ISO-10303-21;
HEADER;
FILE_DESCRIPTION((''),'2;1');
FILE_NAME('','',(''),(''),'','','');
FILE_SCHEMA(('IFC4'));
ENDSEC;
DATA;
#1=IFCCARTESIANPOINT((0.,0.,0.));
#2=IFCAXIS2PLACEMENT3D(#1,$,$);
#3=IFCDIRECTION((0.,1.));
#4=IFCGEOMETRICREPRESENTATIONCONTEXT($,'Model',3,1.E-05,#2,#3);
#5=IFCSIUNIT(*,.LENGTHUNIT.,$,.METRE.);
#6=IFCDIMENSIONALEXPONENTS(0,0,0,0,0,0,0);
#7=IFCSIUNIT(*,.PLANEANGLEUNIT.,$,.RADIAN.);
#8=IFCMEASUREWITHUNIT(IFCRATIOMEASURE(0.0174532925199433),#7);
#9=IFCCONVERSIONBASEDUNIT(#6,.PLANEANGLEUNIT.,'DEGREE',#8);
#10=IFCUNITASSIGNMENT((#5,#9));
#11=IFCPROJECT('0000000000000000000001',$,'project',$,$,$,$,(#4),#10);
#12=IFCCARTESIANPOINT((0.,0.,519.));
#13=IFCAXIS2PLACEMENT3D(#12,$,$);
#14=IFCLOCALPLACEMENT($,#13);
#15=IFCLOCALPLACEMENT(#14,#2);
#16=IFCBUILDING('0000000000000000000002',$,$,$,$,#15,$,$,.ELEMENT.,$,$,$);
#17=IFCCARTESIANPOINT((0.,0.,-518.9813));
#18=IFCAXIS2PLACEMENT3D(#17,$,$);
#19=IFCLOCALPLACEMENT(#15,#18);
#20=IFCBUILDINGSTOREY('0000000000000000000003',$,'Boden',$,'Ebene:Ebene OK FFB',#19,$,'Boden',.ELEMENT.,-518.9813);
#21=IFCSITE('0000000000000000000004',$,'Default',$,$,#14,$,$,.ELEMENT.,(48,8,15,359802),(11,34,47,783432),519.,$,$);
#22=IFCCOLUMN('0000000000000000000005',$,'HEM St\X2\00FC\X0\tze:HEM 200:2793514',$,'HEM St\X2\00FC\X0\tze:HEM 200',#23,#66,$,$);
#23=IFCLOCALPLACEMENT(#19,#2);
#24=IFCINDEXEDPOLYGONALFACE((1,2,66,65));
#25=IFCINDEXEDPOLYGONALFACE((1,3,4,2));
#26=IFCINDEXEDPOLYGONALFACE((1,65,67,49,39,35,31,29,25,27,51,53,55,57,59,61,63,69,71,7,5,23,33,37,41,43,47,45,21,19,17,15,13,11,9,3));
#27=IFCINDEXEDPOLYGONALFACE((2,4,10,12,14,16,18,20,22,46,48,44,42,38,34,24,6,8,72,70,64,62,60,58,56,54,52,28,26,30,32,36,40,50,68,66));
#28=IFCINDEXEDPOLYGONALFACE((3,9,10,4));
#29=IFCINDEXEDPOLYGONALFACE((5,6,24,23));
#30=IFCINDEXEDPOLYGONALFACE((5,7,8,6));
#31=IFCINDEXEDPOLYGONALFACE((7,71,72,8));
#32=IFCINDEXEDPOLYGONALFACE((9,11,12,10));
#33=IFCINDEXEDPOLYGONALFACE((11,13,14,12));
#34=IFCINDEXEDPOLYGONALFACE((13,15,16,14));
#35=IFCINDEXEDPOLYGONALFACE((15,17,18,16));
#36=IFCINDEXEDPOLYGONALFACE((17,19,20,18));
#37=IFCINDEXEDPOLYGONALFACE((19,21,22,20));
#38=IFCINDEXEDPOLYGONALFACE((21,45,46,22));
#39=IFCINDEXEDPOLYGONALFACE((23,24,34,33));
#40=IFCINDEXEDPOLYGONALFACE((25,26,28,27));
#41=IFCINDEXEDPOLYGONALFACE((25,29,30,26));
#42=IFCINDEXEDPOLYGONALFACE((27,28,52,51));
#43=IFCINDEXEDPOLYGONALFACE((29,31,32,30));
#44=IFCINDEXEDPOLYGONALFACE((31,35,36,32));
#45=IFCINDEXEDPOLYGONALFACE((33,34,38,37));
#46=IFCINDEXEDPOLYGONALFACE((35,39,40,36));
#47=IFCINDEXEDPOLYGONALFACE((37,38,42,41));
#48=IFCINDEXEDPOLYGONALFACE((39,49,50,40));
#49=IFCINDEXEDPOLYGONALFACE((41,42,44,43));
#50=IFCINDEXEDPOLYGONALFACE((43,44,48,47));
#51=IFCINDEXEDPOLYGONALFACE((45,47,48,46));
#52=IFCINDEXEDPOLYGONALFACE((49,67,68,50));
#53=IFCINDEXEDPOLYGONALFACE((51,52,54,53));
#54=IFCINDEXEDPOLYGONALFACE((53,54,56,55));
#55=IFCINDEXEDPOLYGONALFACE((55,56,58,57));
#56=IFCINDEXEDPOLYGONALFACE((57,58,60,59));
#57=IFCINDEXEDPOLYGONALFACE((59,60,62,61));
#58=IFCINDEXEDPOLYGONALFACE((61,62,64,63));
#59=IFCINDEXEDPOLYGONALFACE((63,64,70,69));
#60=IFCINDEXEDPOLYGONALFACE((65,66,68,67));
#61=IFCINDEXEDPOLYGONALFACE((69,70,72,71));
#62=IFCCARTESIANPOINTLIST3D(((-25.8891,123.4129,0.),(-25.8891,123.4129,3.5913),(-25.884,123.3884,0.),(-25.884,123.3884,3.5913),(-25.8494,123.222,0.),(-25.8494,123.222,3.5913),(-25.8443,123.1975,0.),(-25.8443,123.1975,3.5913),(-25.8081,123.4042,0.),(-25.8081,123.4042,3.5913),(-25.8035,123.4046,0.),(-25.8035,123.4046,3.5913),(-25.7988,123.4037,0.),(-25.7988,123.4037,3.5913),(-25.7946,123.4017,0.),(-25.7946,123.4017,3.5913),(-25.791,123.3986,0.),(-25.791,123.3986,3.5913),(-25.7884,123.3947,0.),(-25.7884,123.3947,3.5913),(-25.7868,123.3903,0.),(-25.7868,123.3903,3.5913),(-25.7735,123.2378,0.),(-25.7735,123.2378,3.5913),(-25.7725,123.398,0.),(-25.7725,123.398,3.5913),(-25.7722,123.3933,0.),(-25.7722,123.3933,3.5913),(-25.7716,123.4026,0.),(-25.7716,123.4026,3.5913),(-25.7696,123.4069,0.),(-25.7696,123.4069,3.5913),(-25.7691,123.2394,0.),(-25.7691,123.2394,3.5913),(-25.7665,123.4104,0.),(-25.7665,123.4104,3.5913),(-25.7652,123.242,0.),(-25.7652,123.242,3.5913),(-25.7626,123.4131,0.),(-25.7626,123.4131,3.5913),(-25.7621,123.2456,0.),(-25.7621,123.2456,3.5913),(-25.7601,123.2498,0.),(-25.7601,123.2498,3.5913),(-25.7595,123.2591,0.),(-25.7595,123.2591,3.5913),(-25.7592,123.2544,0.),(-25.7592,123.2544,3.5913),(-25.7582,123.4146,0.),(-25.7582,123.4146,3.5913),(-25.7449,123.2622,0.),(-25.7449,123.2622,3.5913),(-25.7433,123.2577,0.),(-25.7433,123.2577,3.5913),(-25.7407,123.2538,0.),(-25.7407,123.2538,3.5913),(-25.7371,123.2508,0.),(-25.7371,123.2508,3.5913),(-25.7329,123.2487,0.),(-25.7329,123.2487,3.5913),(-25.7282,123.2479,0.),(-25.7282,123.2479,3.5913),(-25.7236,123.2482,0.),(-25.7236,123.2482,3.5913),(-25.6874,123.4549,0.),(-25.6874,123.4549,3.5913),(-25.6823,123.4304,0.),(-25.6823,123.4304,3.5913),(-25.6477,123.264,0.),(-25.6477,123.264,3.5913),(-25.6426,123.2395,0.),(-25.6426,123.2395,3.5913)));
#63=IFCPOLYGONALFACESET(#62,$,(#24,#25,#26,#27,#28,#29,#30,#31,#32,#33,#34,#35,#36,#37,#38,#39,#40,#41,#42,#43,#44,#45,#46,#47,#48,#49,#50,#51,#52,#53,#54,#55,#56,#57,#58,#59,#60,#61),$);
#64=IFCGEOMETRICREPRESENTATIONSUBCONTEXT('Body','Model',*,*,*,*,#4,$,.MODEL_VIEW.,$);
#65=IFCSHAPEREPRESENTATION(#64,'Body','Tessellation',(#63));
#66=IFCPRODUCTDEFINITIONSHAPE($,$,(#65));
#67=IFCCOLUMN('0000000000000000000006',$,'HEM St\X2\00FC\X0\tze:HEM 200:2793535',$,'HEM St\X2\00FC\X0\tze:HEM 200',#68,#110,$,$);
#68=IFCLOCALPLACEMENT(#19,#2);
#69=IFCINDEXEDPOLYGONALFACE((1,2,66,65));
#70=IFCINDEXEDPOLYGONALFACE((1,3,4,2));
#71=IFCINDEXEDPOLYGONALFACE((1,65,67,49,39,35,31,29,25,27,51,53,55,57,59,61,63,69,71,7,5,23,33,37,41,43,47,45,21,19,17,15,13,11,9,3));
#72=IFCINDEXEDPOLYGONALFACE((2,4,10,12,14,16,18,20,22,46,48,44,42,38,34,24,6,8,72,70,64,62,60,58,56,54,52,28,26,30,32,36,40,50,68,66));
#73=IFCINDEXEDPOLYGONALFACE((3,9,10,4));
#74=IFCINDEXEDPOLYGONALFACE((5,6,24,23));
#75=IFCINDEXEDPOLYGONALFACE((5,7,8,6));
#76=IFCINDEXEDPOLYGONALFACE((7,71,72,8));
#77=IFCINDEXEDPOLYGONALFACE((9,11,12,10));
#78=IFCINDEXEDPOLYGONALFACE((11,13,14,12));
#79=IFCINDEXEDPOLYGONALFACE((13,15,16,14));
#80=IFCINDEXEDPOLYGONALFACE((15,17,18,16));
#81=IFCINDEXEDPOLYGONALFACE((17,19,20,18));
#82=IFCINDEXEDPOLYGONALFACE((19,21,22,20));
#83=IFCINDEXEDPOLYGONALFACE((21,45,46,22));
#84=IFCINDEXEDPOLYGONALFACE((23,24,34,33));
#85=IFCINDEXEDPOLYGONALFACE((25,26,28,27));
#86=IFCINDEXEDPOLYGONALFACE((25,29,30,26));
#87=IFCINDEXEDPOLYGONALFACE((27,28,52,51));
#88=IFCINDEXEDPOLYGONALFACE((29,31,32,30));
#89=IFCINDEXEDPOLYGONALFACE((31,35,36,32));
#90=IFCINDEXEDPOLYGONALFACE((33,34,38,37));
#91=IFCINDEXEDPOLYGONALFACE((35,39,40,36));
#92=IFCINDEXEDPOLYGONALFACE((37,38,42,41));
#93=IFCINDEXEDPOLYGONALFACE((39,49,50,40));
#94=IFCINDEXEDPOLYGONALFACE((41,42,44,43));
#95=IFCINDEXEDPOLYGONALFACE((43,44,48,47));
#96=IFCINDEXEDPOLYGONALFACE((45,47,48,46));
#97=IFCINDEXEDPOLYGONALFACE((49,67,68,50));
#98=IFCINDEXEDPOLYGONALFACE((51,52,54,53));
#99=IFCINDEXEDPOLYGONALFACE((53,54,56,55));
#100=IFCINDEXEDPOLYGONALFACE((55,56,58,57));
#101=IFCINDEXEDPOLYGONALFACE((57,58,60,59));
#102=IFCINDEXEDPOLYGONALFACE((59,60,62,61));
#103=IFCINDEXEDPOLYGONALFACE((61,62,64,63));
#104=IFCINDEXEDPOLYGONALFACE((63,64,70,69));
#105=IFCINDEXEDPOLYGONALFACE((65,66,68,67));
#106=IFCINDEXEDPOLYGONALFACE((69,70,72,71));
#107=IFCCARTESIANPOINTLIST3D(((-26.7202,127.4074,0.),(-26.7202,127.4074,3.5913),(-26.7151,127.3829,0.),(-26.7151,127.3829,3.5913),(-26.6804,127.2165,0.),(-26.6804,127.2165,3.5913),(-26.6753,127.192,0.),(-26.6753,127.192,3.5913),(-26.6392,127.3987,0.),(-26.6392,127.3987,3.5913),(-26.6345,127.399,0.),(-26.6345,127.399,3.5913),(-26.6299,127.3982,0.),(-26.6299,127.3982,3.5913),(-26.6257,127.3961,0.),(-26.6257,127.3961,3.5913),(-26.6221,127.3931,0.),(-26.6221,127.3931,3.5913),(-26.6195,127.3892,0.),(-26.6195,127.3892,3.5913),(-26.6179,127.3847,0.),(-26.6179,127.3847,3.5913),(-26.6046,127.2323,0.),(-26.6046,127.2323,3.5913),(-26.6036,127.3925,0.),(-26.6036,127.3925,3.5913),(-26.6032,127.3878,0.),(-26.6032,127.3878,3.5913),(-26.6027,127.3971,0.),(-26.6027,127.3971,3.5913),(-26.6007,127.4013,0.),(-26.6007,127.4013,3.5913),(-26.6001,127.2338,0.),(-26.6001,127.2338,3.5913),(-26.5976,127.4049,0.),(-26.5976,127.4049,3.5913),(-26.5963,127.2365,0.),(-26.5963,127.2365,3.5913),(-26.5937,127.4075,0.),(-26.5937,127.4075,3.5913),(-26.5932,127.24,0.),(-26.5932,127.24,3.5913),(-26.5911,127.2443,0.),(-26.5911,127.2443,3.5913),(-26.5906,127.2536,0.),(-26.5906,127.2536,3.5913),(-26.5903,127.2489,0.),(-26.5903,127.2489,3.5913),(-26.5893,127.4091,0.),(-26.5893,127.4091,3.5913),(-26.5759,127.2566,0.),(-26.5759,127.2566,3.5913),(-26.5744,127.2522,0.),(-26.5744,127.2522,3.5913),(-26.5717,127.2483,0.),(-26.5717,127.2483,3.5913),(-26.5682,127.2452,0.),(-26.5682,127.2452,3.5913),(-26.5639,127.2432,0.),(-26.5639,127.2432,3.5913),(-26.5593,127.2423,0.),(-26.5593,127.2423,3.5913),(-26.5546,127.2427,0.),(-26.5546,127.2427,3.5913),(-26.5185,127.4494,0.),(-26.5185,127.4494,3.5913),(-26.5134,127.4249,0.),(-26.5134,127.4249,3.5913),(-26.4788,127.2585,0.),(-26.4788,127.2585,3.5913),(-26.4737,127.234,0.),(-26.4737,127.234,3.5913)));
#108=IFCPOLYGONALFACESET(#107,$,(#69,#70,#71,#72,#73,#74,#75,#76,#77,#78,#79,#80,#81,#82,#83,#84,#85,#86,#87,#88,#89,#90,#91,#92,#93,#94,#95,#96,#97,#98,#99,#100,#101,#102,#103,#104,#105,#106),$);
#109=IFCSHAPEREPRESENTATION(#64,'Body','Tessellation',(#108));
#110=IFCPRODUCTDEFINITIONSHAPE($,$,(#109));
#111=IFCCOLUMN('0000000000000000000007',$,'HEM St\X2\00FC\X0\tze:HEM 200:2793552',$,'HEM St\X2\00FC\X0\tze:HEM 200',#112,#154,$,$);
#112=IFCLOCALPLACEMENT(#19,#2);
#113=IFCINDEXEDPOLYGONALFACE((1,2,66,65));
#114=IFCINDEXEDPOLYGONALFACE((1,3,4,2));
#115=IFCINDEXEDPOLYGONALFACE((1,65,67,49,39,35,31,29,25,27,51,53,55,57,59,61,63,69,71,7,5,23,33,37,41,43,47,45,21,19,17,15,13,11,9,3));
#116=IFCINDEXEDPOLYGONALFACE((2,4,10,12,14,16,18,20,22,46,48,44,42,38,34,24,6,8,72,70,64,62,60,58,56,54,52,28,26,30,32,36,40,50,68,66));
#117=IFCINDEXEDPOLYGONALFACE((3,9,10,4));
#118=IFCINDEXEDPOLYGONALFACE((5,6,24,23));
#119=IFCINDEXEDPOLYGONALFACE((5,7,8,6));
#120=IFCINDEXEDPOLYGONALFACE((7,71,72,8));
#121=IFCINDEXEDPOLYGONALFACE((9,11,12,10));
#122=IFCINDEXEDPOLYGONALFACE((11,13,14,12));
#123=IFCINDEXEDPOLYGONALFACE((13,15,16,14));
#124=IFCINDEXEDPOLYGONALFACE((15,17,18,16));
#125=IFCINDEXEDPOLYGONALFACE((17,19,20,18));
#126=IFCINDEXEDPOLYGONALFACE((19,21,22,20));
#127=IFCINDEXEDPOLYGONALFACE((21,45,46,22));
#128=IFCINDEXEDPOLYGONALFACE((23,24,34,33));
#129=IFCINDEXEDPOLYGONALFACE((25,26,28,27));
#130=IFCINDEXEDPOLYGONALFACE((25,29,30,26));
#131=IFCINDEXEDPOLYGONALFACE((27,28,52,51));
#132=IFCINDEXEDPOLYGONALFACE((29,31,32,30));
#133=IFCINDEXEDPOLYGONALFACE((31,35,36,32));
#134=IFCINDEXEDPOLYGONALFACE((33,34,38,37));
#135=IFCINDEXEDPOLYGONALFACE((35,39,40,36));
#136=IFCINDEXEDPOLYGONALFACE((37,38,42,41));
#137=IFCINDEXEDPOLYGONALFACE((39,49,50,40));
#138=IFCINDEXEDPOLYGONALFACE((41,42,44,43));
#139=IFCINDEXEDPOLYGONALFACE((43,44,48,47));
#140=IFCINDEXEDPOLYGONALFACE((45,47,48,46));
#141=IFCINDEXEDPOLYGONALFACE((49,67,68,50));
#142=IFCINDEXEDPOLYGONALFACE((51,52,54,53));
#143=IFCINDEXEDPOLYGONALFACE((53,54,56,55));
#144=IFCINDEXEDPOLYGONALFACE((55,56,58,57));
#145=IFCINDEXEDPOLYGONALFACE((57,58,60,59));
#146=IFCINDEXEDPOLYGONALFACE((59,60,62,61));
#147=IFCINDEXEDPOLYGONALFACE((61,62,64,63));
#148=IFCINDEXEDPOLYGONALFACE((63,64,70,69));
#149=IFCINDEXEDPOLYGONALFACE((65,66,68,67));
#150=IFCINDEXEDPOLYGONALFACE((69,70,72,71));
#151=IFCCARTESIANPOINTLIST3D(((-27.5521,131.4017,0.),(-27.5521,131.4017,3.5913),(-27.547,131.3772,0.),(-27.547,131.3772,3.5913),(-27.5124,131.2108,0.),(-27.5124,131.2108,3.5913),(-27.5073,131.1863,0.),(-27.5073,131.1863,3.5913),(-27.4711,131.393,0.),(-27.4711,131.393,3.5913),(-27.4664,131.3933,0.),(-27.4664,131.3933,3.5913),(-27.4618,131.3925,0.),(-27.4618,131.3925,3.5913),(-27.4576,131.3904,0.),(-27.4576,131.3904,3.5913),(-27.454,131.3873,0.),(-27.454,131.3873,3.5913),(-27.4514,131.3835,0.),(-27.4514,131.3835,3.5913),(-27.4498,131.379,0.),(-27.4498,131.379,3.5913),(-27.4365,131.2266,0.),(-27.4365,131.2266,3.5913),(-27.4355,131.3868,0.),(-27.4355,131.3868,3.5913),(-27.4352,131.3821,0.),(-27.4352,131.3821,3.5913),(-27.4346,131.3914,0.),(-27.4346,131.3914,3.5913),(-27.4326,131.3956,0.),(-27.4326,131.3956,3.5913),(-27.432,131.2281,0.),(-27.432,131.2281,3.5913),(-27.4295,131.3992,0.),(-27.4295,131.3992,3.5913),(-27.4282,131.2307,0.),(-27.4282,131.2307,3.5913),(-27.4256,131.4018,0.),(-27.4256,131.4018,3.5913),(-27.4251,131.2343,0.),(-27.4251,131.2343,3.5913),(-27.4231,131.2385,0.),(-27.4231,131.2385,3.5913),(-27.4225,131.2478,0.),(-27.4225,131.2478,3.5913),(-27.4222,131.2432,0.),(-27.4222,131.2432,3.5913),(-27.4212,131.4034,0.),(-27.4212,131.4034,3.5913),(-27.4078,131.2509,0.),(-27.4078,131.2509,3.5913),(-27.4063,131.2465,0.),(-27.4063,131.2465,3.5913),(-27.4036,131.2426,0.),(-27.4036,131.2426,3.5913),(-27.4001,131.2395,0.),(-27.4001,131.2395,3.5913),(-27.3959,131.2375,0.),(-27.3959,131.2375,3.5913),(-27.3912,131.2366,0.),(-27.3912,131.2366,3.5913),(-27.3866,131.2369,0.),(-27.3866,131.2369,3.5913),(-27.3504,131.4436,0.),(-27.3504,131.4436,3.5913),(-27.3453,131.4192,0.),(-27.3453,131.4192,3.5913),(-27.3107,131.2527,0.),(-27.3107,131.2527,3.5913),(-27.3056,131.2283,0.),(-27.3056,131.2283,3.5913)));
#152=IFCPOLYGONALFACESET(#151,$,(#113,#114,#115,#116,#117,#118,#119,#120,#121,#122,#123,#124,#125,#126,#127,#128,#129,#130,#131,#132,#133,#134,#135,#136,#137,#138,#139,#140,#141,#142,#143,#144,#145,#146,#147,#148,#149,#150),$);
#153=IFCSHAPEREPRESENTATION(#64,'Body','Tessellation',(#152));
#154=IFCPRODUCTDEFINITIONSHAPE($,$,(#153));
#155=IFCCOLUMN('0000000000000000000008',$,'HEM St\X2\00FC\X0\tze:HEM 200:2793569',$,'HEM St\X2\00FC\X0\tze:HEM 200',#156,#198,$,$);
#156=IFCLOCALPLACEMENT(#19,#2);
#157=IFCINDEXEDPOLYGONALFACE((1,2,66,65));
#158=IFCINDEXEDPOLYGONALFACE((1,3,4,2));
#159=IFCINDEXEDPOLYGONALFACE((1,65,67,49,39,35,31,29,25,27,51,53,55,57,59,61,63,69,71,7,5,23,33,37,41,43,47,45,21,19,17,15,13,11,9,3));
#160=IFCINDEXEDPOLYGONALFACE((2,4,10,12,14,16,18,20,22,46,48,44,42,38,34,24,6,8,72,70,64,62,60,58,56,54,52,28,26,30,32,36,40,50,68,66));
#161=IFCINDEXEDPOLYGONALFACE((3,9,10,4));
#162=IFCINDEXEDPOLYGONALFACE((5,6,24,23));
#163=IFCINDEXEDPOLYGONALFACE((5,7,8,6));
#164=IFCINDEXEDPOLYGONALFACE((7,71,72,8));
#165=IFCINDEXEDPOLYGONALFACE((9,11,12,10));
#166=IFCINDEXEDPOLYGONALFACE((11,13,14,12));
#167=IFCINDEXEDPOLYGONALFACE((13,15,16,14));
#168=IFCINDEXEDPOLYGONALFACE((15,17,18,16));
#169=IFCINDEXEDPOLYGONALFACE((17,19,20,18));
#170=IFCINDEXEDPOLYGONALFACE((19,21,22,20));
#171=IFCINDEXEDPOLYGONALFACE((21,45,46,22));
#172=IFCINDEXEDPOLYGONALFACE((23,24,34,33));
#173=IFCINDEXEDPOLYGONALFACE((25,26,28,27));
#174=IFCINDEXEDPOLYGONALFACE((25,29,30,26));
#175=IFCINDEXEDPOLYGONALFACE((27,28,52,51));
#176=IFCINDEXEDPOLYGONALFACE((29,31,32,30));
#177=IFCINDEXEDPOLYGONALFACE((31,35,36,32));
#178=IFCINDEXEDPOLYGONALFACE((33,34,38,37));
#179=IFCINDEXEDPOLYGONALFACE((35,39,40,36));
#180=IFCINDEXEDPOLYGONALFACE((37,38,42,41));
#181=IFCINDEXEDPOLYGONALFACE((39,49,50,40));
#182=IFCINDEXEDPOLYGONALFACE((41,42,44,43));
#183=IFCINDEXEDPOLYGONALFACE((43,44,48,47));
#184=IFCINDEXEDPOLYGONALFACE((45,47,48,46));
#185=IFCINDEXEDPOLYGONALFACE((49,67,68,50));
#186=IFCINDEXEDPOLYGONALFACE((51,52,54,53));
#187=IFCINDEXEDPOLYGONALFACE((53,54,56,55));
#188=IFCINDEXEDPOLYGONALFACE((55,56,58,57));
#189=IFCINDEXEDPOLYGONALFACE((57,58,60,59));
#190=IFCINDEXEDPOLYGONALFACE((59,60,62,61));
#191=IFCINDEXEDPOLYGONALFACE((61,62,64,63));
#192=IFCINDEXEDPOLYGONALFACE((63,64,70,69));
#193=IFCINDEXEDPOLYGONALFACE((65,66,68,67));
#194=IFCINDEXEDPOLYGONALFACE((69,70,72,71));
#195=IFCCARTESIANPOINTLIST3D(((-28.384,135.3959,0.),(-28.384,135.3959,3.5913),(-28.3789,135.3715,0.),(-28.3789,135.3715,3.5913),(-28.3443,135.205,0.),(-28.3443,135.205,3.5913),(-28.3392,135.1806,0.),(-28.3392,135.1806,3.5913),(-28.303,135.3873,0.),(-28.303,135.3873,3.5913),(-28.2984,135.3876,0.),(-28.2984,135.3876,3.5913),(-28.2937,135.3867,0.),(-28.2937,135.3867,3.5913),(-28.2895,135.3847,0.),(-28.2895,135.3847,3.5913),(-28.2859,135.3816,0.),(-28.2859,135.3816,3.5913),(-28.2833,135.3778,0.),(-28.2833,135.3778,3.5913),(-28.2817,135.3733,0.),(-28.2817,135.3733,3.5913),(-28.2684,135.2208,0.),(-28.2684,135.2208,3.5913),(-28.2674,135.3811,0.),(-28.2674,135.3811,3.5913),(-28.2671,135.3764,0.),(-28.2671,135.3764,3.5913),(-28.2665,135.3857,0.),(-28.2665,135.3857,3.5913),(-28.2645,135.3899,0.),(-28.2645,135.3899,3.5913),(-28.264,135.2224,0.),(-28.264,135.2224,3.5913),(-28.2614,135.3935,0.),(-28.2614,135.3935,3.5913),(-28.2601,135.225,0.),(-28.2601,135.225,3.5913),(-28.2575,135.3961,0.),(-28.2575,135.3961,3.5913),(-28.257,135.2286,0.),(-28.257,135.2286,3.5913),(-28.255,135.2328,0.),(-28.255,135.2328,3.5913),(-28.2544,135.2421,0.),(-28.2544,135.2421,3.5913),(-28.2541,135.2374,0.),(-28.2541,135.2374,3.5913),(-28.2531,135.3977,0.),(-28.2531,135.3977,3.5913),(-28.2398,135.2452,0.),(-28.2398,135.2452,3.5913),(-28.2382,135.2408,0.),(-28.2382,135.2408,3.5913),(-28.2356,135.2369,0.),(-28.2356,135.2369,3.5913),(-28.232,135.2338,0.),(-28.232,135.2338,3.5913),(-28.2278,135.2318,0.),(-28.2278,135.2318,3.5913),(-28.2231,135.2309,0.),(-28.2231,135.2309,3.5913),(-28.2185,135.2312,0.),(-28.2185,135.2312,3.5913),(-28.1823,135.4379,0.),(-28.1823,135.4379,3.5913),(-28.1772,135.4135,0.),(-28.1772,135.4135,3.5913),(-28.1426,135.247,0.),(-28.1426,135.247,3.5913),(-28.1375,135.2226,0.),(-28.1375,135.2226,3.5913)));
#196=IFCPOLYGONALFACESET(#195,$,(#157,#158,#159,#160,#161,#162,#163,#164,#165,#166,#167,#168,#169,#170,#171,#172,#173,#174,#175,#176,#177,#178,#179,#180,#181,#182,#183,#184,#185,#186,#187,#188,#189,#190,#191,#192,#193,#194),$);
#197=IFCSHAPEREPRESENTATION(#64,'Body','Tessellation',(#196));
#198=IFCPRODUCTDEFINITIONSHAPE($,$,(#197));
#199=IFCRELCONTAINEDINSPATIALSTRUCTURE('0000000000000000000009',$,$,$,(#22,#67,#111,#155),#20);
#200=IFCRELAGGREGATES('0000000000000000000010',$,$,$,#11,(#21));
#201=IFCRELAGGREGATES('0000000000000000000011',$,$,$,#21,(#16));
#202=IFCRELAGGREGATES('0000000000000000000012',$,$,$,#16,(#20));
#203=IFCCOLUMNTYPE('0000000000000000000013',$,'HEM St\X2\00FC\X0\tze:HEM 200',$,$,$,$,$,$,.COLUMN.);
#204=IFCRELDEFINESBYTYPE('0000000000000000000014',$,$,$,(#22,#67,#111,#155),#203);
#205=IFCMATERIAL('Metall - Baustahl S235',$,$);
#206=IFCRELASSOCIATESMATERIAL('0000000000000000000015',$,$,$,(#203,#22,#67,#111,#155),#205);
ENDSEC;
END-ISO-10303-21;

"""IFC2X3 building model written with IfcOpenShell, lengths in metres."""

from ifc_helpers import new_model, entity, si_unit, converted_unit, direction, frame, frame_2d, origin, place, context, subcontext, project, spatial, polyline, circle_curve, parameter, trimmed, segment, composite_curve, outline, extrude, source, transform, mapped, material, type_object, type_shapes, element, save


model = new_model("IFC2X3")

# Units and contexts
model_context = context("Model", 3, precision=1e-05, world=origin(), true_north=direction((0.0, 1.0)))
body_context = subcontext(model_context, "Body", "Model", "MODEL_VIEW")
ifc_project = project(units=[si_unit("LENGTHUNIT", "METRE"), converted_unit("PLANEANGLEUNIT", "DEGREE", entity("IfcRatioMeasure", 0.0174532925199433), si_unit("PLANEANGLEUNIT", "RADIAN"), dimensions=[0, 0, 0, 0, 0, 0, 0])], contexts=[model_context])

# Site, building, storey
site_placement = place(None, frame((0.0, 0.0, 519.0)))
site = spatial("IfcSite", under=ifc_project, at=site_placement, Name="Default", CompositionType="ELEMENT", RefLatitude=(48, 8, 15, 359802), RefLongitude=(11, 34, 47, 783432), RefElevation=519.0)
building_placement = place(site_placement, origin())
building = spatial("IfcBuilding", under=site, at=building_placement, CompositionType="ELEMENT")
storey_placement = place(building_placement, frame((0.0, 0.0, -518.9813)))
storey = spatial("IfcBuildingStorey", under=building, at=storey_placement, Name="Boden", ObjectType="Ebene:Ebene OK FFB", LongName="Boden", CompositionType="ELEMENT", Elevation=-518.9813)

# Columns
ifc_material = material(Name="Metall - Baustahl S235")
column_type = type_object("IfcColumnType", Name="HEM Stütze:HEM 200", PredefinedType="COLUMN", material=ifc_material)
shared_shape = source(origin(), body_context, "Body", "SweptSolid", [
    extrude(outline(composite_curve([segment(polyline([(0.085, -0.103), (0.11, -0.103)]), True, "CONTINUOUS"), segment(polyline([(0.11, -0.103), (0.11, 0.103)]), True, "CONTINUOUS"), segment(polyline([(0.11, 0.103), (0.085, 0.103)]), True, "CONTINUOUS"), segment(polyline([(0.085, 0.103), (0.085, 0.0255)]), True, "CONTINUOUS"), segment(trimmed(circle_curve(frame_2d((0.067, 0.0255), x_axis=(1.0, 0.0)), 0.018), [parameter(270.0)], [parameter(0.0)], True, "PARAMETER"), False, "CONTINUOUS"), segment(polyline([(0.067, 0.0075), (-0.067, 0.0075)]), True, "CONTINUOUS"), segment(trimmed(circle_curve(frame_2d((-0.067, 0.0255), x_axis=(0.0, -1.0)), 0.018), [parameter(270.0)], [parameter(0.0)], True, "PARAMETER"), False, "CONTINUOUS"), segment(polyline([(-0.085, 0.0255), (-0.085, 0.103)]), True, "CONTINUOUS"), segment(polyline([(-0.085, 0.103), (-0.11, 0.103)]), True, "CONTINUOUS"), segment(polyline([(-0.11, 0.103), (-0.11, -0.103)]), True, "CONTINUOUS"), segment(polyline([(-0.11, -0.103), (-0.085, -0.103)]), True, "CONTINUOUS"), segment(polyline([(-0.085, -0.103), (-0.085, -0.0255)]), True, "CONTINUOUS"), segment(trimmed(circle_curve(frame_2d((-0.067, -0.0255), x_axis=(-1.0, 0.0)), 0.018), [parameter(270.0)], [parameter(0.0)], True, "PARAMETER"), False, "CONTINUOUS"), segment(polyline([(-0.067, -0.0075), (0.067, -0.0075)]), True, "CONTINUOUS"), segment(trimmed(circle_curve(frame_2d((0.067, -0.0255), x_axis=(0.0, 1.0)), 0.018), [parameter(270.0)], [parameter(0.0)], True, "PARAMETER"), False, "CONTINUOUS"), segment(polyline([(0.085, -0.0255), (0.085, -0.103)]), True, "CONTINUOUS")], self_intersect=False)), frame((0.0, 0.0, -518.9813), z_axis=(0.0, 0.0, 1.0), x_axis=(0.0, -1.0, 0.0)), (0.0, 0.0, 1.0), 3.5913),
])
type_shapes(column_type, [shared_shape])
for number, where, z_axis, x_axis, name in (
    (1, (-25.7659, 123.3262, 518.9813), (0.0, 0.0, 1.0), (0.979008, 0.20382, 0.0), "HEM Stütze:HEM 200:2793514"),
    (2, (-26.5969, 127.3207, 518.9813), (0.0, 0.0, 1.0), (0.979008, 0.20382, 0.0), "HEM Stütze:HEM 200:2793535"),
    (3, (-27.4288, 131.315, 518.9813), (0.0, 0.0, 1.0), (0.979008, 0.20382, 0.0), "HEM Stütze:HEM 200:2793552"),
    (4, (-28.2608, 135.3093, 518.9813), (0.0, 0.0, 1.0), (0.979008, 0.20382, 0.0), "HEM Stütze:HEM 200:2793569"),
):
    element("IfcColumn", number, at=place(storey_placement, frame(where, z_axis=z_axis, x_axis=x_axis)), inside=storey, type_object=column_type, material=ifc_material, Name=name, ObjectType="HEM Stütze:HEM 200", context=body_context, shape_type="MappedRepresentation", body=[
        mapped(shared_shape, transform((0.0, 0.0, 0.0), scale=1.0)),
    ])

save(model, "model.ifc")
